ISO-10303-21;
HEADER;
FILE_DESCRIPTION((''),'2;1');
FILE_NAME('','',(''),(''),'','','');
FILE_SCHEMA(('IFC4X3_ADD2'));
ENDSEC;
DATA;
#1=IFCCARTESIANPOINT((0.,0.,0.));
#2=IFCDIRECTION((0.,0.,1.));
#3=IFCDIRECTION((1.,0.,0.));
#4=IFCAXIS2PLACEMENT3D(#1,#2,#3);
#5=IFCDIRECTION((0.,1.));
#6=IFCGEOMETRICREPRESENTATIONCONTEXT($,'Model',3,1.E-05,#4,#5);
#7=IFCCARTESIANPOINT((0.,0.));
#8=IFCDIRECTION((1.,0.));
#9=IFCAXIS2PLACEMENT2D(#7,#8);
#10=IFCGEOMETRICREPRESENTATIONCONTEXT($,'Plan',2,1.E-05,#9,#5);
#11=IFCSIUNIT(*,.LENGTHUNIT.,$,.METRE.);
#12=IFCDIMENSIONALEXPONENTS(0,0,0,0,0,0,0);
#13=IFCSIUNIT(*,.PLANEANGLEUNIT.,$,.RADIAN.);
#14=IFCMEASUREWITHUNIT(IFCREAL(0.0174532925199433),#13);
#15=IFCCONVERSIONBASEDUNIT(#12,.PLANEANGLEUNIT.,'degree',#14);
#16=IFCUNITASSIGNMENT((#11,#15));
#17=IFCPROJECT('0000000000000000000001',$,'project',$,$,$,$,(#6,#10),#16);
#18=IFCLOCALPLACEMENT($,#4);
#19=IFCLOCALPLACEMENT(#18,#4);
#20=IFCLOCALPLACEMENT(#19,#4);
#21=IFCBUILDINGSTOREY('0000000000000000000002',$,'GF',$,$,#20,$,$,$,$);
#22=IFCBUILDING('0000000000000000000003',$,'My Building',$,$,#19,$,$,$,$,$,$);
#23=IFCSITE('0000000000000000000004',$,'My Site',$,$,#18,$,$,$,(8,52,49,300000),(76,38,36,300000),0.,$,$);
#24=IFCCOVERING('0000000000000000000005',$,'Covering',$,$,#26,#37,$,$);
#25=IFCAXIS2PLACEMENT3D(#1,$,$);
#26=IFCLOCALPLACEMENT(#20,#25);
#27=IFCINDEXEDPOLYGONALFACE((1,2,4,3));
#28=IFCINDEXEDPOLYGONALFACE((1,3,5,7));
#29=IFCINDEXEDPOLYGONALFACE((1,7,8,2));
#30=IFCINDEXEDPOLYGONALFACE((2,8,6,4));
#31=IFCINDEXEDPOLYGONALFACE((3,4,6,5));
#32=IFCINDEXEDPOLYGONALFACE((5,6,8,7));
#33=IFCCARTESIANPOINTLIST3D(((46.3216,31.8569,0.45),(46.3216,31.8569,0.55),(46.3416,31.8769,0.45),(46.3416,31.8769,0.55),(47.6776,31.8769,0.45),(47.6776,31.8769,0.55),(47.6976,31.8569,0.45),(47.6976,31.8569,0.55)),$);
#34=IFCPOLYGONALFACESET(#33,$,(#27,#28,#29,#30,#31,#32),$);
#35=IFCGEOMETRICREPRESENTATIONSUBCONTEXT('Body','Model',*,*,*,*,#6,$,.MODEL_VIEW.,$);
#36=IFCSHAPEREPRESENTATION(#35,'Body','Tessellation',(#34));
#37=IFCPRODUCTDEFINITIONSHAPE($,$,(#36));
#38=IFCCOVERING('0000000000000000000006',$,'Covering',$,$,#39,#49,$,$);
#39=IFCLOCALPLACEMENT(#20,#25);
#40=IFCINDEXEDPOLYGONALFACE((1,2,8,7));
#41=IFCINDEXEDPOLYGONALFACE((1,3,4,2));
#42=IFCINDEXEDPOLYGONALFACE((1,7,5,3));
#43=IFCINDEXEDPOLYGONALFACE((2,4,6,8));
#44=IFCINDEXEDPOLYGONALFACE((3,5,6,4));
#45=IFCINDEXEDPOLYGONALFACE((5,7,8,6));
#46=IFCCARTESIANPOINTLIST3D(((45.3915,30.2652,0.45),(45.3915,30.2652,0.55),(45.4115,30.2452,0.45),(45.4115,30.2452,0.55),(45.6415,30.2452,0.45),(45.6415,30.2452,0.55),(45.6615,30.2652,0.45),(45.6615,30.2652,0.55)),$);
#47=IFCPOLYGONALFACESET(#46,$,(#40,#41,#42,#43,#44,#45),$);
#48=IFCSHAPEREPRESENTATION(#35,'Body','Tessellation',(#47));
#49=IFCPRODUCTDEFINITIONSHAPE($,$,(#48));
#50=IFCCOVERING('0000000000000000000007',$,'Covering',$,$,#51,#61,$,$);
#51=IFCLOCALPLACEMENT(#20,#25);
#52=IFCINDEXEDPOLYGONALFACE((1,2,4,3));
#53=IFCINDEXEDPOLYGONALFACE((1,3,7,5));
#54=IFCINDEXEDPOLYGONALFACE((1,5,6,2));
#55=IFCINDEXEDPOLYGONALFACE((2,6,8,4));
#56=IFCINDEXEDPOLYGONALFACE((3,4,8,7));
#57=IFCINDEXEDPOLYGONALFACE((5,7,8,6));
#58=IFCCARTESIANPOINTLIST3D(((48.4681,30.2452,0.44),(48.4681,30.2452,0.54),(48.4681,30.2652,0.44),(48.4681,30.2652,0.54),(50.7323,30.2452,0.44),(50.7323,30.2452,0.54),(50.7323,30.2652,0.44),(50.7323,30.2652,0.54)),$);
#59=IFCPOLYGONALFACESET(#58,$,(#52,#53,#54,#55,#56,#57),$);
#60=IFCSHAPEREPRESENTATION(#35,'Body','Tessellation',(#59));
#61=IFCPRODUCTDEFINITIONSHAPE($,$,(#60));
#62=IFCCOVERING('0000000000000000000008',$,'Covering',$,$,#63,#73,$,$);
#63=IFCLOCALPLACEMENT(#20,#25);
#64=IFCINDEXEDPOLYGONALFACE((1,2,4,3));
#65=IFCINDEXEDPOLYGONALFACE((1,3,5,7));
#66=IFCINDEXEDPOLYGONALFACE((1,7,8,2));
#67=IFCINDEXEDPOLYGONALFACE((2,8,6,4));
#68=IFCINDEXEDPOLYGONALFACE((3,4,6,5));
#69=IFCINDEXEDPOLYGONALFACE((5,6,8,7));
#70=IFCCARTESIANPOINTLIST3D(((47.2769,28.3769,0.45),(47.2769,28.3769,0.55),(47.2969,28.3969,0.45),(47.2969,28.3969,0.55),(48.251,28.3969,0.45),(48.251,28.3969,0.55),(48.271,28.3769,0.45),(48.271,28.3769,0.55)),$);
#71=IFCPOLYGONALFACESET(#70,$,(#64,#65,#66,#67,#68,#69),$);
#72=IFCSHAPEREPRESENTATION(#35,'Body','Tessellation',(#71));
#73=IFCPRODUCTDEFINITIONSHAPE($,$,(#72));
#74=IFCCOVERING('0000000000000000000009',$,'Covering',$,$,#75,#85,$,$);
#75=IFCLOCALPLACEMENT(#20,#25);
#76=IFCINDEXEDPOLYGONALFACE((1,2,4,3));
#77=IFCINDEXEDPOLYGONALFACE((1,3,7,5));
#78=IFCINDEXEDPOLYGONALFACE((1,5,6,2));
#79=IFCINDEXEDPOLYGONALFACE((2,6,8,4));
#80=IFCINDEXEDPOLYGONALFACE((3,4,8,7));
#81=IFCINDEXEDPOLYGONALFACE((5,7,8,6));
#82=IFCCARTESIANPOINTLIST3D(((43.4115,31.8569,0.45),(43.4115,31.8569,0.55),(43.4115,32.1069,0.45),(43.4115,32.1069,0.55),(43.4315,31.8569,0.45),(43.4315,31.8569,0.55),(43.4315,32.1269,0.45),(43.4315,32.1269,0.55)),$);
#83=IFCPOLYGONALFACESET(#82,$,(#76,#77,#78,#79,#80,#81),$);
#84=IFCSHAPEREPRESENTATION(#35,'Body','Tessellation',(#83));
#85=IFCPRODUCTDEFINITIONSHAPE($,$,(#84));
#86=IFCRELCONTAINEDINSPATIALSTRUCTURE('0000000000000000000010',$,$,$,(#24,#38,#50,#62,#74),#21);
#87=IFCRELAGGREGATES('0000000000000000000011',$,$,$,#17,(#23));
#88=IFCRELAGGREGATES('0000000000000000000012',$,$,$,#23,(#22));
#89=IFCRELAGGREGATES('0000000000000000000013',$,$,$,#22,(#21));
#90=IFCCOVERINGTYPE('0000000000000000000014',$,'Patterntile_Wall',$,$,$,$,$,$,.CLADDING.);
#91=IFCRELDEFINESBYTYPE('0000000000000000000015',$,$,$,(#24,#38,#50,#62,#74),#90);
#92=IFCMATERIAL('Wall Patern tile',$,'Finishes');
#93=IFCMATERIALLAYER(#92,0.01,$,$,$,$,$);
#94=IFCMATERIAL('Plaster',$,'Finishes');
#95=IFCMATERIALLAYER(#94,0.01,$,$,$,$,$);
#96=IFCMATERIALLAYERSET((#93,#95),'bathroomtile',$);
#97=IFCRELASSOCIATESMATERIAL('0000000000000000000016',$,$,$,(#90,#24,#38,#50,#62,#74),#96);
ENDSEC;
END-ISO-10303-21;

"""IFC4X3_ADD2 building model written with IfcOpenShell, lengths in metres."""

from ifc_helpers import new_model, entity, si_unit, converted_unit, direction, frame, origin_with_axes, origin_2d_with_axis, place, context, subcontext, project, spatial, line, indexed_curve, outline, extrude, material, layer, layer_set, layer_usage, type_object, element, save


model = new_model("IFC4X3_ADD2")

# Units and contexts
model_context = context("Model", 3, precision=1e-05, world=origin_with_axes(), true_north=direction((0.0, 1.0)))
plan_context = context("Plan", 2, precision=1e-05, world=origin_2d_with_axis(), true_north=direction((0.0, 1.0)))
body_context_1 = subcontext(model_context, "Body", "Model", "MODEL_VIEW")
ifc_project = project(units=[si_unit("LENGTHUNIT", "METRE"), converted_unit("PLANEANGLEUNIT", "degree", entity("IfcReal", 0.0174532925199433), si_unit("PLANEANGLEUNIT", "RADIAN"), dimensions=[0, 0, 0, 0, 0, 0, 0])], contexts=[model_context, plan_context])

# Site, building, storey
site_placement = place(None, origin_with_axes())
site = spatial("IfcSite", under=ifc_project, at=site_placement, Name="My Site", RefLatitude=(8, 52, 49, 300000), RefLongitude=(76, 38, 36, 300000), RefElevation=0.0)
building_placement = place(site_placement, origin_with_axes())
building = spatial("IfcBuilding", under=site, at=building_placement, Name="My Building")
storey_placement = place(building_placement, origin_with_axes())
storey = spatial("IfcBuildingStorey", under=building, at=storey_placement, Name="GF")

# Coverings
ifc_material_1 = material(Name="Wall Patern tile", Category="Finishes")
ifc_layer_1 = layer(ifc_material_1, 0.01)
ifc_material_2 = material(Name="Plaster", Category="Finishes")
ifc_layer_2 = layer(ifc_material_2, 0.01)
ifc_layer_set_1 = layer_set([ifc_layer_1, ifc_layer_2], Name="bathroomtile")
covering_type = type_object("IfcCoveringType", Name="Patterntile_Wall", PredefinedType="CLADDING", material=ifc_layer_set_1)
ifc_layer_usage_1 = layer_usage(ifc_layer_set_1, "AXIS2", "NEGATIVE", 0.0)
covering_1_placement = place(storey_placement, frame((47.6976, 31.8569, 0.45), z_axis=(0.0, 0.0, 1.0), x_axis=(-1.0, 0.000001, 0.0)))
element("IfcCovering", 1, at=covering_1_placement, inside=storey, type_object=covering_type, material=ifc_layer_usage_1, Name="Covering", context=body_context_1, shape_type="SweptSolid", body=[
    extrude(outline(indexed_curve([(0.02, -0.02), (0.0, 0.0), (1.376, 0.0), (1.356, -0.02)], segments=[line(1, 2, 3, 4, 1)])), origin_with_axes(), (0.0, 0.0, 1.0), 0.1),
])
ifc_layer_usage_2 = layer_usage(ifc_layer_set_1, "AXIS2", "NEGATIVE", 0.0)
covering_2_placement = place(storey_placement, frame((45.3915, 30.2652, 0.45), z_axis=(0.0, 0.0, 1.0), x_axis=(1.0, -0.000001, 0.0)))
element("IfcCovering", 2, at=covering_2_placement, inside=storey, type_object=covering_type, material=ifc_layer_usage_2, Name="Covering", context=body_context_1, shape_type="SweptSolid", body=[
    extrude(outline(indexed_curve([(0.02, -0.02), (0.0, 0.0), (0.27, 0.0), (0.25, -0.02)], segments=[line(1, 2, 3, 4, 1)])), origin_with_axes(), (0.0, 0.0, 1.0), 0.1),
])
ifc_layer_usage_3 = layer_usage(ifc_layer_set_1, "AXIS2", "NEGATIVE", 0.0)
covering_3_placement = place(storey_placement, frame((48.4681, 30.2652, 0.44), z_axis=(0.0, 0.0, 1.0), x_axis=(1.0, -0.000001, 0.0)))
element("IfcCovering", 3, at=covering_3_placement, inside=storey, type_object=covering_type, material=ifc_layer_usage_3, Name="Covering", context=body_context_1, shape_type="SweptSolid", body=[
    extrude(outline(indexed_curve([(0.0, -0.02), (0.0, 0.0), (2.2642, 0.0), (2.2642, -0.02)], segments=[line(1, 2, 3, 4, 1)])), origin_with_axes(), (0.0, 0.0, 1.0), 0.1),
])
ifc_layer_usage_4 = layer_usage(ifc_layer_set_1, "AXIS2", "NEGATIVE", 0.0)
covering_4_placement = place(storey_placement, frame((47.2969, 28.3969, 0.45), z_axis=(0.0, 0.0, 1.0), x_axis=(1.0, -0.000001, 0.0)))
element("IfcCovering", 4, at=covering_4_placement, inside=storey, type_object=covering_type, material=ifc_layer_usage_4, Name="Covering", context=body_context_1, shape_type="SweptSolid", body=[
    extrude(outline(indexed_curve([(-0.02, -0.02), (0.0, 0.0), (0.9541, 0.0), (0.9741, -0.02)], segments=[line(1, 2, 3, 4, 1)])), origin_with_axes(), (0.0, 0.0, 1.0), 0.1),
])
ifc_layer_usage_5 = layer_usage(ifc_layer_set_1, "AXIS2", "POSITIVE", 0.0)
covering_5_placement = place(storey_placement, frame((43.4315, 31.8569, 0.45), z_axis=(0.0, 0.0, 1.0), x_axis=(0.000001, 1.0, 0.0)))
element("IfcCovering", 5, at=covering_5_placement, inside=storey, type_object=covering_type, material=ifc_layer_usage_5, Name="Covering", context=body_context_1, shape_type="SweptSolid", body=[
    extrude(outline(indexed_curve([(0.0, 0.0), (0.0, 0.02), (0.25, 0.02), (0.27, 0.0)], segments=[line(1, 2, 3, 4, 1)])), origin_with_axes(), (0.0, 0.0, 1.0), 0.1),
])

save(model, "model.ifc")
